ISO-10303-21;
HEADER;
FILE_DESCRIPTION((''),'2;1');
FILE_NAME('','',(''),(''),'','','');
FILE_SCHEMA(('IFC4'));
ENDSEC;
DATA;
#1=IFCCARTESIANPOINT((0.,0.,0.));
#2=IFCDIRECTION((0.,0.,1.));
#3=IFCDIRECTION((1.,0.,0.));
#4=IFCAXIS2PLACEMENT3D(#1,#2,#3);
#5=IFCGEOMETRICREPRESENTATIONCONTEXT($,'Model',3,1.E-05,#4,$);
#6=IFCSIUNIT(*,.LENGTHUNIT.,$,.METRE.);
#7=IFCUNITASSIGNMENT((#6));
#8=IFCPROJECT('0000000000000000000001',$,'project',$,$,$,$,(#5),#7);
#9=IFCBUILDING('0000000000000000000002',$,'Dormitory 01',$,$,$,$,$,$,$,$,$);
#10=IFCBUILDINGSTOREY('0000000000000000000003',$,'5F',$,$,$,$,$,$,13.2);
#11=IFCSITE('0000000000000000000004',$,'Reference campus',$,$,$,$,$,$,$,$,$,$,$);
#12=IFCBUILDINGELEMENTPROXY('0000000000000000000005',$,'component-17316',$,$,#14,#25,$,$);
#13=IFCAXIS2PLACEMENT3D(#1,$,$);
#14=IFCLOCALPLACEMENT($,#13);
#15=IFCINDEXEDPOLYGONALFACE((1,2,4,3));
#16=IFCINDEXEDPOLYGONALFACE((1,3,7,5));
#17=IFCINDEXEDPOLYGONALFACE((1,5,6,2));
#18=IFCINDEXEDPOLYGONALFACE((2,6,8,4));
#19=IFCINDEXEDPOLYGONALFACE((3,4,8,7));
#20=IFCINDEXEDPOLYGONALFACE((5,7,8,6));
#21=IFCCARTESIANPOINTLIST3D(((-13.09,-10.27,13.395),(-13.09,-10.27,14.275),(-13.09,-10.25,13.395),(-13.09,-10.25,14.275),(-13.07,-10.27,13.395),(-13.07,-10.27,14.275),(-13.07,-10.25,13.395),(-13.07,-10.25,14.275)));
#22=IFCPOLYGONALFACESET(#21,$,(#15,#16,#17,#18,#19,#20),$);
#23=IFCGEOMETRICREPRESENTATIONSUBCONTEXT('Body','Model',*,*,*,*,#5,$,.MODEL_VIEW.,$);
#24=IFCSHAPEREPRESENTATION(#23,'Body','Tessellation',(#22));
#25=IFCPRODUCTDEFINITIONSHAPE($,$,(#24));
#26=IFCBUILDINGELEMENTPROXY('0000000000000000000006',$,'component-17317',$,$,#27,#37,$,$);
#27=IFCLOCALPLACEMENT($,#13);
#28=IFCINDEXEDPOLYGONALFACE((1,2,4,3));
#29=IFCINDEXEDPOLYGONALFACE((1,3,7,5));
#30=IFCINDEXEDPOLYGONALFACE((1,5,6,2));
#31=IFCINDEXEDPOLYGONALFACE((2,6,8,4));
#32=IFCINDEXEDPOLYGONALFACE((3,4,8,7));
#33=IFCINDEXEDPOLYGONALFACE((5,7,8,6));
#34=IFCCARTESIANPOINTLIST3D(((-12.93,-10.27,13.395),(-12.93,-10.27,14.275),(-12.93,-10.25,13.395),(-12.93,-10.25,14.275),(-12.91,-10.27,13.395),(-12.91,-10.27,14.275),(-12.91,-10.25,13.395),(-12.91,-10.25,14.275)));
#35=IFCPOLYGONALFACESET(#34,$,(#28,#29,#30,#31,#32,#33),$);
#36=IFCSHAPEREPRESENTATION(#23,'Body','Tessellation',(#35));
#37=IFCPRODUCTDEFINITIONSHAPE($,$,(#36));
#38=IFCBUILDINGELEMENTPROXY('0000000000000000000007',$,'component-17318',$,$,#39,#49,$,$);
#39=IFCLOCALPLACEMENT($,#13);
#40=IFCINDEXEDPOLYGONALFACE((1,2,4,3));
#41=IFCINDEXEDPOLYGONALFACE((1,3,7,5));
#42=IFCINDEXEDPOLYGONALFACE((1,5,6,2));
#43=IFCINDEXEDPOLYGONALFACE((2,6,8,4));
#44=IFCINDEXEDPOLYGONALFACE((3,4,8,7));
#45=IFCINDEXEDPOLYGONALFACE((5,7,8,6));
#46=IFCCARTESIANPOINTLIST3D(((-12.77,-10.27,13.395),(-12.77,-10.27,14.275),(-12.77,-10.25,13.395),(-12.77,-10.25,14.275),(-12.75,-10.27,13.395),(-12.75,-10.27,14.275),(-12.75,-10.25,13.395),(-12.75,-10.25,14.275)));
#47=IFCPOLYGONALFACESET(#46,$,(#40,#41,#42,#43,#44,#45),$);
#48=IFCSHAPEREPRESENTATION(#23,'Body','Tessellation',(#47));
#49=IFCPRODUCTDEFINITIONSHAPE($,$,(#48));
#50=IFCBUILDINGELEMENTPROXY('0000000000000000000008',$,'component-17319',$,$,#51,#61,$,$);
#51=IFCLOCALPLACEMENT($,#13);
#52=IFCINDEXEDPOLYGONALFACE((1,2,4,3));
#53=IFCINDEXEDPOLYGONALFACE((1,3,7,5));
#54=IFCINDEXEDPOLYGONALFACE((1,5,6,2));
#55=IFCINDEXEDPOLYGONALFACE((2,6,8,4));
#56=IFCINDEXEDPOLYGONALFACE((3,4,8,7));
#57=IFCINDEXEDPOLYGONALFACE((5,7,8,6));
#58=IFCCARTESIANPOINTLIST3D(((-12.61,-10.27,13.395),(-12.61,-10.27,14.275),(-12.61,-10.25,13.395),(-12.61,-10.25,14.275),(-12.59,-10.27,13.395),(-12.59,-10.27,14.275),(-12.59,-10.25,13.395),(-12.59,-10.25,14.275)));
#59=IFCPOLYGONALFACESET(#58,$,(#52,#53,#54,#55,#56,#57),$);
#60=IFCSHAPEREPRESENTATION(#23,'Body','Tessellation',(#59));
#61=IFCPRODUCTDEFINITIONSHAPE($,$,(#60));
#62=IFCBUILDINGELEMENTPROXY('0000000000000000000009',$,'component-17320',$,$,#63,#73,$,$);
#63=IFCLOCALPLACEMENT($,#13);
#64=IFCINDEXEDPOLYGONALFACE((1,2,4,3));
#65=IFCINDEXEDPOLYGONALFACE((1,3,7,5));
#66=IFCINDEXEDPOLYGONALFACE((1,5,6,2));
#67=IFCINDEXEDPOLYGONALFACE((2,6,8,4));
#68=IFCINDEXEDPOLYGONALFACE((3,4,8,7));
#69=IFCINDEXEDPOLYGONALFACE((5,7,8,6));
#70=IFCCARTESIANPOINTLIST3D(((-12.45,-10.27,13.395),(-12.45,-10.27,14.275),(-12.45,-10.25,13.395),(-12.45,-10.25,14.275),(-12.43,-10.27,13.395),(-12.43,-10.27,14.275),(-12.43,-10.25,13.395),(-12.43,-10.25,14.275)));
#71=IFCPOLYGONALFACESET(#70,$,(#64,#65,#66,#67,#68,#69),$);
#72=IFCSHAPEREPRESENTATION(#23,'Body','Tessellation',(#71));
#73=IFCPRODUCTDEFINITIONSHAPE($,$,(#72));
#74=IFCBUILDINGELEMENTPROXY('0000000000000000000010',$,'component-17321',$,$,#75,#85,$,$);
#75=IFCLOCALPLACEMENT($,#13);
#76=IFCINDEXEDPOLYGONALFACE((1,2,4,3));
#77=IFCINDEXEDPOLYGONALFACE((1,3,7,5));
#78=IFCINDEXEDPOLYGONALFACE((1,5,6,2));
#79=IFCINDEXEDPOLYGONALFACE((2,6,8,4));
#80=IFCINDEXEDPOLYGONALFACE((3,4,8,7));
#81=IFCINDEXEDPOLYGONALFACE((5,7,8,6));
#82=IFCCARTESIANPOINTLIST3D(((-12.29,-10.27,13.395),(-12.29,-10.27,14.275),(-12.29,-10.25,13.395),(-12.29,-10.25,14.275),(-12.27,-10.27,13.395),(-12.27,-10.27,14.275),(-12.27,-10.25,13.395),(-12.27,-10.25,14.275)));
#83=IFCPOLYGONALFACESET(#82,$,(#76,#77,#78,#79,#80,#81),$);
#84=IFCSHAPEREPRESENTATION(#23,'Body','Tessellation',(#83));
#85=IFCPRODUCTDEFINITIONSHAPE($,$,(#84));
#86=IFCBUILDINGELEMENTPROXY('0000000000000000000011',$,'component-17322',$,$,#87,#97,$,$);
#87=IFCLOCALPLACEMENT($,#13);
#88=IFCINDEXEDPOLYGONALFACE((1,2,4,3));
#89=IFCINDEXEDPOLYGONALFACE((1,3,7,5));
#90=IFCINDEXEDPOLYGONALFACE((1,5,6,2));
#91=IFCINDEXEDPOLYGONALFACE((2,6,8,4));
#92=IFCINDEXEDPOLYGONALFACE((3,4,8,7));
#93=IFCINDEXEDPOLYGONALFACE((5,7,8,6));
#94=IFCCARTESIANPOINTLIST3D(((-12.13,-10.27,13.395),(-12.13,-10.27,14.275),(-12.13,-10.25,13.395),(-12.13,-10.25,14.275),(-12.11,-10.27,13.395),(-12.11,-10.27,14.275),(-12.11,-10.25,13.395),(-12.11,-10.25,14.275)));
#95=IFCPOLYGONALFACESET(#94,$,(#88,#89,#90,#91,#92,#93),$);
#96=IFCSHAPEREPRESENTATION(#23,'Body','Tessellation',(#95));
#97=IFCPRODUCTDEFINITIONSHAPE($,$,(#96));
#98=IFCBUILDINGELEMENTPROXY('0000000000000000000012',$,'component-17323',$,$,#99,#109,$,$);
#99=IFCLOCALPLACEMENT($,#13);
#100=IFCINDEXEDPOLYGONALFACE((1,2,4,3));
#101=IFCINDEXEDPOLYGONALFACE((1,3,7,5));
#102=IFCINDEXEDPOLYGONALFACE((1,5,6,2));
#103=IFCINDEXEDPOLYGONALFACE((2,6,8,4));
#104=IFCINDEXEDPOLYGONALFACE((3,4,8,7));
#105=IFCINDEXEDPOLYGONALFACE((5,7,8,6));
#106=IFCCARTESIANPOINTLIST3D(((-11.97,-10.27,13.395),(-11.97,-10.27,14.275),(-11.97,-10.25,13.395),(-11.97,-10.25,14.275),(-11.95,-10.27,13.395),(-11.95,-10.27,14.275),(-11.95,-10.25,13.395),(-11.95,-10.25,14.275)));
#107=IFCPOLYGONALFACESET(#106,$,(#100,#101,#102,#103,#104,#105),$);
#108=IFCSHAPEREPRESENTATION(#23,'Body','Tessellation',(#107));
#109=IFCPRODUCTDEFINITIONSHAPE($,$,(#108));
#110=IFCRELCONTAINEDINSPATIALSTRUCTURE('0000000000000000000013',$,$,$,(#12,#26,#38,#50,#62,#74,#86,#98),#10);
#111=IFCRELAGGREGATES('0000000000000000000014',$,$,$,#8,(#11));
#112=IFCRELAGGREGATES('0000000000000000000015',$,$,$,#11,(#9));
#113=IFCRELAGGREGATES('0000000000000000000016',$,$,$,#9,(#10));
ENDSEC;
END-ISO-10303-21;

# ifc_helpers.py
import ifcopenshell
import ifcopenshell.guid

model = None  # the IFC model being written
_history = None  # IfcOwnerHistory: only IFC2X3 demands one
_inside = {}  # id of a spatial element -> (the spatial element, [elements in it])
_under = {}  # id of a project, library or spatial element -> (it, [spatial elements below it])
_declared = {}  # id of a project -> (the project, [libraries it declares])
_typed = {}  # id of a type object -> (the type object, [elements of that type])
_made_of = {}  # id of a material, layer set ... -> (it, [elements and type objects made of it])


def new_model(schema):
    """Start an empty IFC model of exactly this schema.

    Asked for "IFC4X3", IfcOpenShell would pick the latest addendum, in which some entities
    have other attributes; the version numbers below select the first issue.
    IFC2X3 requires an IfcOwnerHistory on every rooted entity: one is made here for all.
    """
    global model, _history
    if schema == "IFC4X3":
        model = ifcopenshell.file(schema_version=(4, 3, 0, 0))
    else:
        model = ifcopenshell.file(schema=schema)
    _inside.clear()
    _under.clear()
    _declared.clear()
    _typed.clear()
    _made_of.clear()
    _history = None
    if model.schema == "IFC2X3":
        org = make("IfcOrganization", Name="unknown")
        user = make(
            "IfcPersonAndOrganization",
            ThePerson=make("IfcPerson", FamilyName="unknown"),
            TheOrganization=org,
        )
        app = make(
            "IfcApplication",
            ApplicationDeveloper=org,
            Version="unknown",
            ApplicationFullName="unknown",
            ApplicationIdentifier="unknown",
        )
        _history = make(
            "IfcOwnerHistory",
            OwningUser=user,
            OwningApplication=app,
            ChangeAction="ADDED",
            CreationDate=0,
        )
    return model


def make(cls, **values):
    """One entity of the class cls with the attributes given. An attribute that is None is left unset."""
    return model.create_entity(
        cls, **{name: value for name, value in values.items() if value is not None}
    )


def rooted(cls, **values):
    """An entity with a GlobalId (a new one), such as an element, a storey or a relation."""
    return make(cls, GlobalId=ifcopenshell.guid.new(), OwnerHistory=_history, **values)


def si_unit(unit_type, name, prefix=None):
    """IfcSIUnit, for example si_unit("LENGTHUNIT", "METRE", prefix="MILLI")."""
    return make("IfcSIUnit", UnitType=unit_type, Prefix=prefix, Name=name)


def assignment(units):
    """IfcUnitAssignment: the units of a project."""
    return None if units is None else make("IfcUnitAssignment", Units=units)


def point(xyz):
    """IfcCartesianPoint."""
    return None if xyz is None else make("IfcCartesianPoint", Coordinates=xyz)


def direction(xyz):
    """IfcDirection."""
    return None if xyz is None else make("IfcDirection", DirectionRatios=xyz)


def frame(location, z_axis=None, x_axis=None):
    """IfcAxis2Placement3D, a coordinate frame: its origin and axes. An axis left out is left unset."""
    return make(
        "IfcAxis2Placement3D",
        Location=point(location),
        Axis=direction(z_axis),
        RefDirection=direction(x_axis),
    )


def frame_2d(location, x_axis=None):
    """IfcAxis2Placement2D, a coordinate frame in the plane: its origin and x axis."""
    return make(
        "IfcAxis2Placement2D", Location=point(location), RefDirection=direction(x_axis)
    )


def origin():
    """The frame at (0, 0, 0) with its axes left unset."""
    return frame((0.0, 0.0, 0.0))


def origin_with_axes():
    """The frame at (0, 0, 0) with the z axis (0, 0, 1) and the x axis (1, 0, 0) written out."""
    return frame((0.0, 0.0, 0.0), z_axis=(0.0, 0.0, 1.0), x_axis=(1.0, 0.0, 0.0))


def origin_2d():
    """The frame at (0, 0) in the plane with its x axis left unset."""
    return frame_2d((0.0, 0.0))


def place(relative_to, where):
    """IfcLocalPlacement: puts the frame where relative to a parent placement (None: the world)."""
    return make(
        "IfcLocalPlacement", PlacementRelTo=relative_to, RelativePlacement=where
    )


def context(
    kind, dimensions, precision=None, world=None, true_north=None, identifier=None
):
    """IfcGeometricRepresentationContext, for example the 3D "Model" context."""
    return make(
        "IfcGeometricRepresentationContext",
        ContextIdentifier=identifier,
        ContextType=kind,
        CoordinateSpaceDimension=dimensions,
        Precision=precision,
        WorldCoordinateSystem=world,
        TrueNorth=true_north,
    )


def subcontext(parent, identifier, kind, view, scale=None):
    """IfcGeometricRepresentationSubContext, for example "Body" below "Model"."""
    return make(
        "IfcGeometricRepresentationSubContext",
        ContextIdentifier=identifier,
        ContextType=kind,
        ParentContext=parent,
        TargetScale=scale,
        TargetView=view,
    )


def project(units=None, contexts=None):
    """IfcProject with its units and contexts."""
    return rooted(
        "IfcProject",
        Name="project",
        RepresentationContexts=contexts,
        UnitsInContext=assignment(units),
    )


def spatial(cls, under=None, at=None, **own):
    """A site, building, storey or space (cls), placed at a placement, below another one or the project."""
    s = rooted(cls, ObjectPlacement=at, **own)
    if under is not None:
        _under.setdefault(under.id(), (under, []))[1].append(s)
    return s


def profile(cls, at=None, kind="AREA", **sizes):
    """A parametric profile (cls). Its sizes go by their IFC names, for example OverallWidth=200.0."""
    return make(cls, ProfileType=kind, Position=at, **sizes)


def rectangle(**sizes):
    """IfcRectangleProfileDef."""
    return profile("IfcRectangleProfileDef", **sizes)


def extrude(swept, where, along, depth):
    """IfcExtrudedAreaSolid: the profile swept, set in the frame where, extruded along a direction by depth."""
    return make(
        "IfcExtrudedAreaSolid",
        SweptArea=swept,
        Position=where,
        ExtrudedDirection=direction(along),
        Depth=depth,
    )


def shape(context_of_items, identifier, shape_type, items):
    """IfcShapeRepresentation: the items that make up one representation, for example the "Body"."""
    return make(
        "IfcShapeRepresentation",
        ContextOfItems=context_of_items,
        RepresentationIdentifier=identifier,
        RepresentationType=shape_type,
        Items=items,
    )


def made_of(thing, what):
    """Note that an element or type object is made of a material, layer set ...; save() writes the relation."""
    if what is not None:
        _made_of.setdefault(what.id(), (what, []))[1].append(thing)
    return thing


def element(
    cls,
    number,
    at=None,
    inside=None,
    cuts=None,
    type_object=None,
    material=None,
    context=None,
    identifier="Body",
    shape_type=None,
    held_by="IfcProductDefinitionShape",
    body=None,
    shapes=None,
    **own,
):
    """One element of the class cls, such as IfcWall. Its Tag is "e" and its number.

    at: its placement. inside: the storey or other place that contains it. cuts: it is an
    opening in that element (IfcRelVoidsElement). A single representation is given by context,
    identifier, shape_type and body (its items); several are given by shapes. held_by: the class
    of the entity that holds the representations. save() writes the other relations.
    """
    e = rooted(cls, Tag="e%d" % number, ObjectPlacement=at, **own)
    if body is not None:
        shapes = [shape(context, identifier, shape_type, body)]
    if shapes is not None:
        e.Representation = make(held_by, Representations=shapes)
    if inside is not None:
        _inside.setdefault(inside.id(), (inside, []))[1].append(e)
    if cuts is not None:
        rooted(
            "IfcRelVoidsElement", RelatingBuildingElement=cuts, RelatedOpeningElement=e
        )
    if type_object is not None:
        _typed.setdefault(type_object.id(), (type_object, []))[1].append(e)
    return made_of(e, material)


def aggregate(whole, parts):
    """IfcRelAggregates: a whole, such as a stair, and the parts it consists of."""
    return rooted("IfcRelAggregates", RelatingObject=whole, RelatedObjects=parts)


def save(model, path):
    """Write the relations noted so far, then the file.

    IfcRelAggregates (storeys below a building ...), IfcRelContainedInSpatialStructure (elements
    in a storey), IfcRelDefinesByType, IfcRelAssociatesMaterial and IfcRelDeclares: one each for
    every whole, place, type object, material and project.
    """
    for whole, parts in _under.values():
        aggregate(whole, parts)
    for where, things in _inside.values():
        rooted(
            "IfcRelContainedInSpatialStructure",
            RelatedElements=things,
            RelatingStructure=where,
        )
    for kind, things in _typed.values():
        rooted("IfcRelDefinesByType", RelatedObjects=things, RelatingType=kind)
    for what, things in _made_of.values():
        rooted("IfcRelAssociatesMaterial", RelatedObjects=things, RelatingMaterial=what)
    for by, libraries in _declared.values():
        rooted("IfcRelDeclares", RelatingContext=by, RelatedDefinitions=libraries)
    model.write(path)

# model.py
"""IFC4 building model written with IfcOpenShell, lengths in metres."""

from ifc_helpers import new_model, si_unit, frame, origin, origin_with_axes, origin_2d, place, context, subcontext, project, spatial, rectangle, extrude, element, save


model = new_model("IFC4")

# Units and contexts
model_context = context("Model", 3, precision=1e-05, world=origin_with_axes())
body_context = subcontext(model_context, "Body", "Model", "MODEL_VIEW")
ifc_project = project(units=[si_unit("LENGTHUNIT", "METRE")], contexts=[model_context])

# Site, building, storey
site = spatial("IfcSite", under=ifc_project, Name="Reference campus")
building = spatial("IfcBuilding", under=site, Name="Dormitory 01")
storey = spatial("IfcBuildingStorey", under=building, Name="5F", Elevation=13.2)

# Building element proxies
for number, where, z_axis, x_axis, name in (
    (1, (-13.08, -10.26, 13.395), (0.0, 0.0, 1.0), (1.0, 0.0, 0.0), "component-17316"),
    (2, (-12.92, -10.26, 13.395), (0.0, 0.0, 1.0), (1.0, 0.0, 0.0), "component-17317"),
    (3, (-12.76, -10.26, 13.395), (0.0, 0.0, 1.0), (1.0, 0.0, 0.0), "component-17318"),
    (4, (-12.6, -10.26, 13.395), (0.0, 0.0, 1.0), (1.0, 0.0, 0.0), "component-17319"),
    (5, (-12.44, -10.26, 13.395), (0.0, 0.0, 1.0), (1.0, 0.0, 0.0), "component-17320"),
    (6, (-12.28, -10.26, 13.395), (0.0, 0.0, 1.0), (1.0, 0.0, 0.0), "component-17321"),
    (7, (-12.12, -10.26, 13.395), (0.0, 0.0, 1.0), (1.0, 0.0, 0.0), "component-17322"),
    (8, (-11.96, -10.26, 13.395), (0.0, 0.0, 1.0), (1.0, 0.0, 0.0), "component-17323"),
):
    element("IfcBuildingElementProxy", number, at=place(None, frame(where, z_axis=z_axis, x_axis=x_axis)), inside=storey, Name=name, context=body_context, shape_type="SweptSolid", body=[
        extrude(rectangle(XDim=0.02, YDim=0.02, at=origin_2d()), origin(), (0.0, 0.0, 1.0), 0.88),
    ])

save(model, "model.ifc")
